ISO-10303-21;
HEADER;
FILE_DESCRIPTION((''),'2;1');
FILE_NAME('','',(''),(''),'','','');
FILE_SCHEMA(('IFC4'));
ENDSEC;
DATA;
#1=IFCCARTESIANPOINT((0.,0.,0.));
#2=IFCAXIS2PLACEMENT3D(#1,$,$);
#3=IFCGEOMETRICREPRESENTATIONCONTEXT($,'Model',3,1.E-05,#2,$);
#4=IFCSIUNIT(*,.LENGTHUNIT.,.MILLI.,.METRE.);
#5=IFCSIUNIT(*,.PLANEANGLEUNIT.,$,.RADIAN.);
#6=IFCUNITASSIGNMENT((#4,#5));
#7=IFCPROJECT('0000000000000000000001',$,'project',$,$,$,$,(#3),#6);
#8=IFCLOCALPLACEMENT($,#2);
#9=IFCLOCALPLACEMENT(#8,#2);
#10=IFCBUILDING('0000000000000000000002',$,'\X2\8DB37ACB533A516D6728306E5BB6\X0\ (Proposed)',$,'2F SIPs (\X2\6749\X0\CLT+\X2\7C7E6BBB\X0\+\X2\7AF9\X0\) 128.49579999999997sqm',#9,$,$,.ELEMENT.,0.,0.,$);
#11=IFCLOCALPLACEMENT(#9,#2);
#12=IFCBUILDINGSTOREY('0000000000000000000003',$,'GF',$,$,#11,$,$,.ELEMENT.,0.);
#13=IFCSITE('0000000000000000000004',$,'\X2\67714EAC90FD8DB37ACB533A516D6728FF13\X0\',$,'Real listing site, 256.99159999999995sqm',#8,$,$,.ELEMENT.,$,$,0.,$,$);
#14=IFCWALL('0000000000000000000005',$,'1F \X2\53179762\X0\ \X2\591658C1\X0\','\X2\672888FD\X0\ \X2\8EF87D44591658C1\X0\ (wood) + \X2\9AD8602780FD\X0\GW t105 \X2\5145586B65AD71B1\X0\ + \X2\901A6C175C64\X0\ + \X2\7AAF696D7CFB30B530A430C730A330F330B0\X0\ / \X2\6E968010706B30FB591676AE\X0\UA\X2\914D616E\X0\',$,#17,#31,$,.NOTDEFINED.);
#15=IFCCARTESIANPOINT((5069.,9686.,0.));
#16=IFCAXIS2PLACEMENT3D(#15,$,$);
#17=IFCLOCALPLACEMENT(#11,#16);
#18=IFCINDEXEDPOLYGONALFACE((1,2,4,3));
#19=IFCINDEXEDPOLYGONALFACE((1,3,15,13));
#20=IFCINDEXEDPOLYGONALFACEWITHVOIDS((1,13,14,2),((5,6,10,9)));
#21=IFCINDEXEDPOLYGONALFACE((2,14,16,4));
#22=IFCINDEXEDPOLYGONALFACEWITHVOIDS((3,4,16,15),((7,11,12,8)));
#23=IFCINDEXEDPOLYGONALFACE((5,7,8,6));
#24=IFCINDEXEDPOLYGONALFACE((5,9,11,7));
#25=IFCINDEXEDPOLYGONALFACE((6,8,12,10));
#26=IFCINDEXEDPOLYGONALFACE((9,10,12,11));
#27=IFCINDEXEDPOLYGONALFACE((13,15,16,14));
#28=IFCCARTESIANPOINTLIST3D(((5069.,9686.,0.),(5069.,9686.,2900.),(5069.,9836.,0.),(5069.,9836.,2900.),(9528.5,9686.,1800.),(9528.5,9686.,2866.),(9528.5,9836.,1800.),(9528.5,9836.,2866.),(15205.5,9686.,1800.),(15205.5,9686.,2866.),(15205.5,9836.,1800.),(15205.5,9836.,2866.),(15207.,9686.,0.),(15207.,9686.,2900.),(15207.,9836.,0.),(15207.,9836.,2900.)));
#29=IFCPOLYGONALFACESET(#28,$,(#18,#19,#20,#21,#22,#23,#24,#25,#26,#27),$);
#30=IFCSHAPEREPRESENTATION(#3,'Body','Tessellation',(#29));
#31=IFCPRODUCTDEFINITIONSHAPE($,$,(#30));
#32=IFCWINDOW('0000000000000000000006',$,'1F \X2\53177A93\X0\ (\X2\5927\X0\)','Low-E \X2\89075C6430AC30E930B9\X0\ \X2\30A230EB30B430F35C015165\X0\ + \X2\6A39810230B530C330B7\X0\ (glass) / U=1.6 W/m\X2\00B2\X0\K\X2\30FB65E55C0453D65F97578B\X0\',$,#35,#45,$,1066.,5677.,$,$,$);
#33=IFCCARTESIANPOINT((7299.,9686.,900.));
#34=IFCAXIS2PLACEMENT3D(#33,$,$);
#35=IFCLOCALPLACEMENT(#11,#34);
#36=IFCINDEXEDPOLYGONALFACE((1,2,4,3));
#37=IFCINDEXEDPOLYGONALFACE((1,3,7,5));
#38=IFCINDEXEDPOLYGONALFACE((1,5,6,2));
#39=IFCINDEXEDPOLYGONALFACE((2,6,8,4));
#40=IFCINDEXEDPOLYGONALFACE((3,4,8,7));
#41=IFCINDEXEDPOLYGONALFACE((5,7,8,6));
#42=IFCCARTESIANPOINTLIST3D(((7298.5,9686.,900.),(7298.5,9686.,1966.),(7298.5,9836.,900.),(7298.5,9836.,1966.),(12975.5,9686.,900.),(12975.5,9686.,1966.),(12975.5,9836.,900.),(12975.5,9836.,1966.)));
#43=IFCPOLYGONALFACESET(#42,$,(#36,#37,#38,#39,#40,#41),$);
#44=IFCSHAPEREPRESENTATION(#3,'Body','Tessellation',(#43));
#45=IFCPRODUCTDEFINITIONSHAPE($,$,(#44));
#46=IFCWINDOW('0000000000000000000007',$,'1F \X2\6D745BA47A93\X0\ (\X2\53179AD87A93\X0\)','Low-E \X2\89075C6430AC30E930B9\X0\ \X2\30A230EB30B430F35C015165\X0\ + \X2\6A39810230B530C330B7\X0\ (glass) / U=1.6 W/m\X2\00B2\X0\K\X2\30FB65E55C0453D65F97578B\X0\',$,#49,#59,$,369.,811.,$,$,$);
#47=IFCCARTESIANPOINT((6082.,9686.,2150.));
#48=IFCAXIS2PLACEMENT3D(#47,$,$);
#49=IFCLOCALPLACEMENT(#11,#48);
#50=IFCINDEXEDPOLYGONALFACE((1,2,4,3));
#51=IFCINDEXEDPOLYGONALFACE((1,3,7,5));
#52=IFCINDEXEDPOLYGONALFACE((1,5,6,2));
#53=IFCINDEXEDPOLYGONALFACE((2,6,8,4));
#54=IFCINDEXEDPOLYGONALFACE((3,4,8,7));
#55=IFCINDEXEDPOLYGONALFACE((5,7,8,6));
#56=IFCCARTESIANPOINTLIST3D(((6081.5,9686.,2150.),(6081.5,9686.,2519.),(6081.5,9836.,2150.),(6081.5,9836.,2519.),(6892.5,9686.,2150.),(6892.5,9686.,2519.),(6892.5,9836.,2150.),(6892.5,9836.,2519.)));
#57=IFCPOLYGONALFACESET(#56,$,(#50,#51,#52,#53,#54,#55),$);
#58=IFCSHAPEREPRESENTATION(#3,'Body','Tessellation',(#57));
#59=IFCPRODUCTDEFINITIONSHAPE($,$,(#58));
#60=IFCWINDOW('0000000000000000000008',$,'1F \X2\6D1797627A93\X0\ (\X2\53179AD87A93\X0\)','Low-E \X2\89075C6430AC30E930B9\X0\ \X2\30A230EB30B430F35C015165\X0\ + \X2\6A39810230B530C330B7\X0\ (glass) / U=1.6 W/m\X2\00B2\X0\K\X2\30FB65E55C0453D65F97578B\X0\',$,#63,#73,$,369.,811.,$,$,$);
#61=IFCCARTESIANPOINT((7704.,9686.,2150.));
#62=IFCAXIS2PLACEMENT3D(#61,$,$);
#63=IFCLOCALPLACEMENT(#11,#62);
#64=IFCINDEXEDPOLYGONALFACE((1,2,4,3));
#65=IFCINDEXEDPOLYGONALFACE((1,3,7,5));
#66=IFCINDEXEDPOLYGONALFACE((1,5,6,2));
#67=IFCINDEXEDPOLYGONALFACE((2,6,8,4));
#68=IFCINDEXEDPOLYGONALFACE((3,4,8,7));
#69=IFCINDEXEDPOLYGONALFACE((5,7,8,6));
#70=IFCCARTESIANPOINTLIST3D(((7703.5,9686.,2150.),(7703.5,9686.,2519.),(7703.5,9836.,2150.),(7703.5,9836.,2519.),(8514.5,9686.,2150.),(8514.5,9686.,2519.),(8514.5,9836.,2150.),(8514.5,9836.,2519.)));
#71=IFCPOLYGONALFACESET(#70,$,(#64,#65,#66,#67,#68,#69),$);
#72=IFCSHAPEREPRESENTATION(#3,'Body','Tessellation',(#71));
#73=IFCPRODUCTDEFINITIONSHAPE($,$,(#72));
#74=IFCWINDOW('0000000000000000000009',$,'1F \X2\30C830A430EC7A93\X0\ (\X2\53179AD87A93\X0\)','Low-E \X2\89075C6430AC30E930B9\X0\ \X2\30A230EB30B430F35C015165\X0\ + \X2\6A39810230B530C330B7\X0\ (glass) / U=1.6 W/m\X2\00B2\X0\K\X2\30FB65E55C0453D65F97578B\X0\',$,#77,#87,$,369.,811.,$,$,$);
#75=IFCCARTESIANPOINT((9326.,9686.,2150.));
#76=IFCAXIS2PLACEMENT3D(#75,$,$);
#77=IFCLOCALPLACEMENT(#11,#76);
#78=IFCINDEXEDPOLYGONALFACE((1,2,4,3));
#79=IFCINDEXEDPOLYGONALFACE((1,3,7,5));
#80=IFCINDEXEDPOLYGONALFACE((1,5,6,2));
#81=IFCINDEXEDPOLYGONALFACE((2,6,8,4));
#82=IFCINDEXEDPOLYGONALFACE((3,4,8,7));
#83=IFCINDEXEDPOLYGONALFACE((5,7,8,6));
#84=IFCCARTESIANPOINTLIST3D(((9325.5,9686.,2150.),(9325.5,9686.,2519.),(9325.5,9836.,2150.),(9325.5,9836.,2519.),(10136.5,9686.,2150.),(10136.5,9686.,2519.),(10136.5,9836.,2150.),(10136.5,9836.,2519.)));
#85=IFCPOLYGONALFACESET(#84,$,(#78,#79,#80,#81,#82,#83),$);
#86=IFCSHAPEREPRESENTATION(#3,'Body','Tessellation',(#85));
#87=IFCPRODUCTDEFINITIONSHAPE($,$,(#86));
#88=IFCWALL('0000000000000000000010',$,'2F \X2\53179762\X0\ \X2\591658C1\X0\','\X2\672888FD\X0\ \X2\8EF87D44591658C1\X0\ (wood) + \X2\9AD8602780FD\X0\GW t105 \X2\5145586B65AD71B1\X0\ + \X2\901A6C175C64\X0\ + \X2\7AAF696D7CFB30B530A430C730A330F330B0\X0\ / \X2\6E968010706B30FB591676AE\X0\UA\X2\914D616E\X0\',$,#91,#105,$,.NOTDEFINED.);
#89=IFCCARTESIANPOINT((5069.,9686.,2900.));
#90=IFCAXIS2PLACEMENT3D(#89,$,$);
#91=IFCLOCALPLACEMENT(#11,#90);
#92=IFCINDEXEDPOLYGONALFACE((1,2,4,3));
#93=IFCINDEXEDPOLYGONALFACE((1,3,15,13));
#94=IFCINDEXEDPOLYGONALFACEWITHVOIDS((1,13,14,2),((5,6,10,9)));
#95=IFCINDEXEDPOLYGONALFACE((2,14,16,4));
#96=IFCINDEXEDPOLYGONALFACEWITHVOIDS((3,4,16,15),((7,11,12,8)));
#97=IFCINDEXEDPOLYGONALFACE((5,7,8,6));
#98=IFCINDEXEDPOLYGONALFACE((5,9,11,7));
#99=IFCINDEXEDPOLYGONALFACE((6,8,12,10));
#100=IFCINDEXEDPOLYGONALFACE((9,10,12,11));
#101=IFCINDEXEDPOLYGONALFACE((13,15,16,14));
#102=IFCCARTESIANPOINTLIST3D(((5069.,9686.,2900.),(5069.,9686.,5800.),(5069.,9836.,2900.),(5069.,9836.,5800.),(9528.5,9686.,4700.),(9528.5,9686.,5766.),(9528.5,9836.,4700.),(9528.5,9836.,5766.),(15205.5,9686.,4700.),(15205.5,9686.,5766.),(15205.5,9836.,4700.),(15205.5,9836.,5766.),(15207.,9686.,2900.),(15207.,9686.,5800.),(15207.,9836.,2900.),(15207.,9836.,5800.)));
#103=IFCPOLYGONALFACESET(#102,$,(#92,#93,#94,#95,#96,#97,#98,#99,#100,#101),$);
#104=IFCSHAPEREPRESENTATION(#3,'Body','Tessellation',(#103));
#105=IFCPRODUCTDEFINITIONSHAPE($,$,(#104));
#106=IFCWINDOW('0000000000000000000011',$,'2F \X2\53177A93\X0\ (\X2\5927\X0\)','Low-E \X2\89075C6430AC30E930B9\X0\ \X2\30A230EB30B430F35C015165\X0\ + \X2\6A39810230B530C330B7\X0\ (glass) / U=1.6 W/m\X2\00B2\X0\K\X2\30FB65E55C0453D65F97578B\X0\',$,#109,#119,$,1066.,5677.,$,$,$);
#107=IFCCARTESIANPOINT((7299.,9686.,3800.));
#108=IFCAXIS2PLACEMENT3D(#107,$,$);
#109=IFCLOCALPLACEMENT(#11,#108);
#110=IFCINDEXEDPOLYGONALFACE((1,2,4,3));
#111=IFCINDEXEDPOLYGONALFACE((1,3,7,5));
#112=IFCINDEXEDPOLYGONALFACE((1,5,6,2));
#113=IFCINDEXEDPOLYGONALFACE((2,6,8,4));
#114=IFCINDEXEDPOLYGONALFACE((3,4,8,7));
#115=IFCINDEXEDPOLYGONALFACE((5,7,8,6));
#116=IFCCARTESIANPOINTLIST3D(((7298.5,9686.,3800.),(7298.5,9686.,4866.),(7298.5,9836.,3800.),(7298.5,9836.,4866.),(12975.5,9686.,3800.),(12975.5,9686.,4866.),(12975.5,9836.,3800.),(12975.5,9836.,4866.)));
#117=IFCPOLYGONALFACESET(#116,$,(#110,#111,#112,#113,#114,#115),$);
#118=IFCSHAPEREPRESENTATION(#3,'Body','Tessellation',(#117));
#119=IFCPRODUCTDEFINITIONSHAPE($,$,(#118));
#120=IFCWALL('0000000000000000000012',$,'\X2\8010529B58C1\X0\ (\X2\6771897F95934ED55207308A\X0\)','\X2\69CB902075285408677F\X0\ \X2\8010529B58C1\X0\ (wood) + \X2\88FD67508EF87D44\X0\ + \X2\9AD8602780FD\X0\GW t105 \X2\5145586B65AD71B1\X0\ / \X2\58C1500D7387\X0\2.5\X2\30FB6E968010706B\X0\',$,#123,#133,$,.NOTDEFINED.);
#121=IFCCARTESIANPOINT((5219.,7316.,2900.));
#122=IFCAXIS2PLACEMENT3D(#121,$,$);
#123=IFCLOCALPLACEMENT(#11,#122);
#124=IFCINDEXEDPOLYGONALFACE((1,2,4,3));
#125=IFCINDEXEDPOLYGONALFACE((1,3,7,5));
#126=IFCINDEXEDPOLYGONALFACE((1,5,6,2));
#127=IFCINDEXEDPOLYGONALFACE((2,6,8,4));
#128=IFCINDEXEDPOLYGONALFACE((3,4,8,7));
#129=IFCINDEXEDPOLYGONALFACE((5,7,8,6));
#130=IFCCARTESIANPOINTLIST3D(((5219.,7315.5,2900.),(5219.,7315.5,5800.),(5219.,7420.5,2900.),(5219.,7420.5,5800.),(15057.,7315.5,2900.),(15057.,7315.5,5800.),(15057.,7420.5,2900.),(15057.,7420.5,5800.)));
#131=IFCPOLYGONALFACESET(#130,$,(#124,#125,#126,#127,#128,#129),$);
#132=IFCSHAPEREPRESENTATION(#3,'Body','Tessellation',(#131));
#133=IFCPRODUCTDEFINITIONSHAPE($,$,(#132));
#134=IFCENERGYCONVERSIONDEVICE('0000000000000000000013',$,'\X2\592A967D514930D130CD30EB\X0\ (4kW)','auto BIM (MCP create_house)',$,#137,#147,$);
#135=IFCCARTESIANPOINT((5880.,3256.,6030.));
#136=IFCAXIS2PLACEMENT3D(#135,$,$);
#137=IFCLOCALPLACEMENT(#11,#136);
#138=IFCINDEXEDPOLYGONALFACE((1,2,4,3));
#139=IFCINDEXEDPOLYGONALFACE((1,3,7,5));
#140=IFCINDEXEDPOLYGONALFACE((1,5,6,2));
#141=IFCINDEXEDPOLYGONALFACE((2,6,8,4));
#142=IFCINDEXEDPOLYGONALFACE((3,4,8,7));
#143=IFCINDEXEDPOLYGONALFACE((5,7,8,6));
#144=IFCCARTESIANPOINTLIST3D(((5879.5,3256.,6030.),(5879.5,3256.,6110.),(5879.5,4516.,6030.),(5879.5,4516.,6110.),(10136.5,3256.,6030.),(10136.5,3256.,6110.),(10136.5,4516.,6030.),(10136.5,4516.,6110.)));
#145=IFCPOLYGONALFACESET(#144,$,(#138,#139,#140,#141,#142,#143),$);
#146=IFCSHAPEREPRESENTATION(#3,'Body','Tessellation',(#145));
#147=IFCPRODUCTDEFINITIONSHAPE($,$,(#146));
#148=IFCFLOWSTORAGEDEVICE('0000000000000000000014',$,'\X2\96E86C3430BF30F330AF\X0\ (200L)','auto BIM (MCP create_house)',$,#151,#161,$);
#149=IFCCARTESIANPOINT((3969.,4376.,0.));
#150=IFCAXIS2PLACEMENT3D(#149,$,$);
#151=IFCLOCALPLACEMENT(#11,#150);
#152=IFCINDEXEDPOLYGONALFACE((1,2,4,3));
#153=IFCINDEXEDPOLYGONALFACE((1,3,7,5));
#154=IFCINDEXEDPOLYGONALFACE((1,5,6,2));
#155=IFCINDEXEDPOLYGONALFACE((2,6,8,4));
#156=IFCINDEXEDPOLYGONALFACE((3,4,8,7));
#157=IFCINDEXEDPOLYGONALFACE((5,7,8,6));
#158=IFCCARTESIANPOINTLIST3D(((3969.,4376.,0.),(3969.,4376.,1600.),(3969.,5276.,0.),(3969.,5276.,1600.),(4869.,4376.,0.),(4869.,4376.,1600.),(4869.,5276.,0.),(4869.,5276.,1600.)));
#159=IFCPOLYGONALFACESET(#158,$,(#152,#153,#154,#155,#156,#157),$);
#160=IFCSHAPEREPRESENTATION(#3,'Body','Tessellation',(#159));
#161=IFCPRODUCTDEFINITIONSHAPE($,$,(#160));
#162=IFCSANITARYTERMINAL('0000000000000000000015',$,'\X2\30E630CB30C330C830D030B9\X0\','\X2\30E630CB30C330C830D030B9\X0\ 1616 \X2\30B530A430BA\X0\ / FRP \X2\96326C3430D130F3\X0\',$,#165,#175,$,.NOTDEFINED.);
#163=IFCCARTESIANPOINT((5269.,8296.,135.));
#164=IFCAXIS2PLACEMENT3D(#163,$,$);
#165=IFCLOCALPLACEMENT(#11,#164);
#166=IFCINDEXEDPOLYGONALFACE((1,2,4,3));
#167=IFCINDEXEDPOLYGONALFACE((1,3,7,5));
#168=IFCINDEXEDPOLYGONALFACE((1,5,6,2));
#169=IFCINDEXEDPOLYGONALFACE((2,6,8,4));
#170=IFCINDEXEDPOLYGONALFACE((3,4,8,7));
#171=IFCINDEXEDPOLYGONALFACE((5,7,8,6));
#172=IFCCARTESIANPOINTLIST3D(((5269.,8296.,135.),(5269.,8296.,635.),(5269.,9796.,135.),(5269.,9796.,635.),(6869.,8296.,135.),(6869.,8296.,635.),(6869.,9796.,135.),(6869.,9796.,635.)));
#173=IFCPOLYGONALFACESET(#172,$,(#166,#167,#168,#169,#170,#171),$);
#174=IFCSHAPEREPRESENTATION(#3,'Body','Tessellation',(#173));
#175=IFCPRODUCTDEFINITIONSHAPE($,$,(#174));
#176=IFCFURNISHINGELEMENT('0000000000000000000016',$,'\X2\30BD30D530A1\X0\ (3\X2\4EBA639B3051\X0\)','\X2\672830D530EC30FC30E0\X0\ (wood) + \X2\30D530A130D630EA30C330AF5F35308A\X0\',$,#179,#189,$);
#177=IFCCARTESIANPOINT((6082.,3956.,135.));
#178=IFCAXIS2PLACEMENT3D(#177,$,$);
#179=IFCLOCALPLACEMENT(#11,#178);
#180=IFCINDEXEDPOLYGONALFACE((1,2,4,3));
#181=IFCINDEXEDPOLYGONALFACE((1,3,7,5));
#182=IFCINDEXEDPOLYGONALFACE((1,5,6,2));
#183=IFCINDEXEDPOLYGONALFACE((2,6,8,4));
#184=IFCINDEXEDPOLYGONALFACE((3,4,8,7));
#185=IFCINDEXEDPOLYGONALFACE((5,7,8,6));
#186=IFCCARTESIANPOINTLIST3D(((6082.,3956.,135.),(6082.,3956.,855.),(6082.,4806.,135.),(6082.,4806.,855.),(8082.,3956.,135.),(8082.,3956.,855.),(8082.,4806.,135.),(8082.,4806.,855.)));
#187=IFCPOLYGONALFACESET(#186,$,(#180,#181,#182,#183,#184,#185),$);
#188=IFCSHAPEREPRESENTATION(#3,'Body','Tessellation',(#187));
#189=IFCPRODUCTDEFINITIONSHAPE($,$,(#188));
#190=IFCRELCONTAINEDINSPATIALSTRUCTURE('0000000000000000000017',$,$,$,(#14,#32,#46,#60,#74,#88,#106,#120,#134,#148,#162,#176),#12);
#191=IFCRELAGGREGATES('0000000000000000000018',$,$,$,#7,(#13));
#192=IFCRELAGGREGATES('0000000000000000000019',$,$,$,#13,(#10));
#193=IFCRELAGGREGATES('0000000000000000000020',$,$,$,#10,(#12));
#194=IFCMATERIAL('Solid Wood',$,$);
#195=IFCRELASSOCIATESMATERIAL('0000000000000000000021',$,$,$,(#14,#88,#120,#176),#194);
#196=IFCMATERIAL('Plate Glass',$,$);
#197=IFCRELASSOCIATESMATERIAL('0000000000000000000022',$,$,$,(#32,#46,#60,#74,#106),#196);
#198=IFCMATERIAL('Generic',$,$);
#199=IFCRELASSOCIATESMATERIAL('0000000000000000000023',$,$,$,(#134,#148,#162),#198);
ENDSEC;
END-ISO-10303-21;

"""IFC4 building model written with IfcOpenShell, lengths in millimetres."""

from ifc_helpers import new_model, si_unit, frame, frame_2d, origin, place, context, project, spatial, rectangle, extrude, material, element, fill, save


model = new_model("IFC4")

# Units and contexts
model_context = context("Model", 3, precision=1e-05, world=origin())
ifc_project = project(units=[si_unit("LENGTHUNIT", "METRE", prefix="MILLI"), si_unit("PLANEANGLEUNIT", "RADIAN")], contexts=[model_context])

# Site, building, storey
site_placement = place(None, origin())
site = spatial("IfcSite", under=ifc_project, at=site_placement, Name="東京都足立区六木３", ObjectType="Real listing site, 256.99159999999995sqm", CompositionType="ELEMENT", RefElevation=0.0)
building_placement = place(site_placement, origin())
building = spatial("IfcBuilding", under=site, at=building_placement, Name="足立区六木の家 (Proposed)", ObjectType="2F SIPs (杉CLT+籾殻+竹) 128.49579999999997sqm", CompositionType="ELEMENT", ElevationOfRefHeight=0.0, ElevationOfTerrain=0.0)
storey_placement = place(building_placement, origin())
storey = spatial("IfcBuildingStorey", under=building, at=storey_placement, Name="GF", CompositionType="ELEMENT", Elevation=0.0)

# Wall, openings, windows
ifc_material_1 = material(Name="Solid Wood")
wall_1_placement = place(storey_placement, frame((5069.0, 9686.0, 0.0)))
wall_1 = element("IfcWall", 1, at=wall_1_placement, inside=storey, material=ifc_material_1, Name="1F 北面 外壁", Description="木製 軸組外壁 (wood) + 高性能GW t105 充填断熱 + 通気層 + 窯業系サイディング / 準耐火・外皮UA配慮", PredefinedType="NOTDEFINED", context=model_context, shape_type="SweptSolid", body=[
    extrude(rectangle(XDim=10138.0, YDim=150.0, at=frame_2d((5069.0, 75.0))), frame((5069.0, 9686.0, 0.0)), (0.0, 0.0, 1.0), 2900.0),
])
opening_1_placement = place(storey_placement, frame((7299.0, 9686.0, 900.0)))
opening_1 = element("IfcOpeningElement", 2, at=opening_1_placement, cuts=wall_1, PredefinedType="NOTDEFINED", context=model_context, shape_type="SweptSolid", body=[
    extrude(rectangle(XDim=5677.0, YDim=150.0, at=frame_2d((2838.0, 75.0))), frame((7299.0, 9686.0, 900.0)), (0.0, 0.0, 1.0), 1066.0),
])
opening_2_placement = place(storey_placement, frame((6082.0, 9686.0, 2150.0)))
opening_2 = element("IfcOpeningElement", 3, at=opening_2_placement, cuts=wall_1, PredefinedType="NOTDEFINED", context=model_context, shape_type="SweptSolid", body=[
    extrude(rectangle(XDim=811.0, YDim=150.0, at=frame_2d((405.0, 75.0))), frame((6082.0, 9686.0, 2150.0)), (0.0, 0.0, 1.0), 369.0),
])
opening_3_placement = place(storey_placement, frame((7704.0, 9686.0, 2150.0)))
opening_3 = element("IfcOpeningElement", 4, at=opening_3_placement, cuts=wall_1, PredefinedType="NOTDEFINED", context=model_context, shape_type="SweptSolid", body=[
    extrude(rectangle(XDim=811.0, YDim=150.0, at=frame_2d((405.0, 75.0))), frame((7704.0, 9686.0, 2150.0)), (0.0, 0.0, 1.0), 369.0),
])
opening_4_placement = place(storey_placement, frame((9326.0, 9686.0, 2150.0)))
opening_4 = element("IfcOpeningElement", 5, at=opening_4_placement, cuts=wall_1, PredefinedType="NOTDEFINED", context=model_context, shape_type="SweptSolid", body=[
    extrude(rectangle(XDim=811.0, YDim=150.0, at=frame_2d((405.0, 75.0))), frame((9326.0, 9686.0, 2150.0)), (0.0, 0.0, 1.0), 369.0),
])
ifc_material_2 = material(Name="Plate Glass")
window_1_placement = place(storey_placement, frame((7299.0, 9686.0, 900.0)))
window_1 = element("IfcWindow", 6, at=window_1_placement, inside=storey, material=ifc_material_2, Name="1F 北窓 (大)", Description="Low-E 複層ガラス アルゴン封入 + 樹脂サッシ (glass) / U=1.6 W/m²K・日射取得型", OverallHeight=1066.0, OverallWidth=5677.0, context=model_context, shape_type="SweptSolid", body=[
    extrude(rectangle(XDim=5677.0, YDim=150.0, at=frame_2d((2838.0, 75.0))), frame((7299.0, 9686.0, 900.0)), (0.0, 0.0, 1.0), 1066.0),
])
fill(opening_1, window_1)
window_2_placement = place(storey_placement, frame((6082.0, 9686.0, 2150.0)))
window_2 = element("IfcWindow", 7, at=window_2_placement, inside=storey, material=ifc_material_2, Name="1F 浴室窓 (北高窓)", Description="Low-E 複層ガラス アルゴン封入 + 樹脂サッシ (glass) / U=1.6 W/m²K・日射取得型", OverallHeight=369.0, OverallWidth=811.0, context=model_context, shape_type="SweptSolid", body=[
    extrude(rectangle(XDim=811.0, YDim=150.0, at=frame_2d((405.0, 75.0))), frame((6082.0, 9686.0, 2150.0)), (0.0, 0.0, 1.0), 369.0),
])
fill(opening_2, window_2)
window_3_placement = place(storey_placement, frame((7704.0, 9686.0, 2150.0)))
window_3 = element("IfcWindow", 8, at=window_3_placement, inside=storey, material=ifc_material_2, Name="1F 洗面窓 (北高窓)", Description="Low-E 複層ガラス アルゴン封入 + 樹脂サッシ (glass) / U=1.6 W/m²K・日射取得型", OverallHeight=369.0, OverallWidth=811.0, context=model_context, shape_type="SweptSolid", body=[
    extrude(rectangle(XDim=811.0, YDim=150.0, at=frame_2d((405.0, 75.0))), frame((7704.0, 9686.0, 2150.0)), (0.0, 0.0, 1.0), 369.0),
])
fill(opening_3, window_3)
window_4_placement = place(storey_placement, frame((9326.0, 9686.0, 2150.0)))
window_4 = element("IfcWindow", 9, at=window_4_placement, inside=storey, material=ifc_material_2, Name="1F トイレ窓 (北高窓)", Description="Low-E 複層ガラス アルゴン封入 + 樹脂サッシ (glass) / U=1.6 W/m²K・日射取得型", OverallHeight=369.0, OverallWidth=811.0, context=model_context, shape_type="SweptSolid", body=[
    extrude(rectangle(XDim=811.0, YDim=150.0, at=frame_2d((405.0, 75.0))), frame((9326.0, 9686.0, 2150.0)), (0.0, 0.0, 1.0), 369.0),
])
fill(opening_4, window_4)

# Wall, opening, window
wall_2_placement = place(storey_placement, frame((5069.0, 9686.0, 2900.0)))
wall_2 = element("IfcWall", 10, at=wall_2_placement, inside=storey, material=ifc_material_1, Name="2F 北面 外壁", Description="木製 軸組外壁 (wood) + 高性能GW t105 充填断熱 + 通気層 + 窯業系サイディング / 準耐火・外皮UA配慮", PredefinedType="NOTDEFINED", context=model_context, shape_type="SweptSolid", body=[
    extrude(rectangle(XDim=10138.0, YDim=150.0, at=frame_2d((5069.0, 75.0))), frame((5069.0, 9686.0, 2900.0)), (0.0, 0.0, 1.0), 2900.0),
])
opening_5_placement = place(storey_placement, frame((7299.0, 9686.0, 3800.0)))
opening_5 = element("IfcOpeningElement", 11, at=opening_5_placement, cuts=wall_2, PredefinedType="NOTDEFINED", context=model_context, shape_type="SweptSolid", body=[
    extrude(rectangle(XDim=5677.0, YDim=150.0, at=frame_2d((2838.0, 75.0))), frame((7299.0, 9686.0, 3800.0)), (0.0, 0.0, 1.0), 1066.0),
])
window_5_placement = place(storey_placement, frame((7299.0, 9686.0, 3800.0)))
window_5 = element("IfcWindow", 12, at=window_5_placement, inside=storey, material=ifc_material_2, Name="2F 北窓 (大)", Description="Low-E 複層ガラス アルゴン封入 + 樹脂サッシ (glass) / U=1.6 W/m²K・日射取得型", OverallHeight=1066.0, OverallWidth=5677.0, context=model_context, shape_type="SweptSolid", body=[
    extrude(rectangle(XDim=5677.0, YDim=150.0, at=frame_2d((2838.0, 75.0))), frame((7299.0, 9686.0, 3800.0)), (0.0, 0.0, 1.0), 1066.0),
])
fill(opening_5, window_5)

# Wall
wall_3_placement = place(storey_placement, frame((5219.0, 7316.0, 2900.0)))
element("IfcWall", 13, at=wall_3_placement, inside=storey, material=ifc_material_1, Name="耐力壁 (東西間仕切り)", Description="構造用合板 耐力壁 (wood) + 製材軸組 + 高性能GW t105 充填断熱 / 壁倍率2.5・準耐火", PredefinedType="NOTDEFINED", context=model_context, shape_type="SweptSolid", body=[
    extrude(rectangle(XDim=9838.0, YDim=105.0, at=frame_2d((4919.0, 52.0))), frame((5219.0, 7316.0, 2900.0)), (0.0, 0.0, 1.0), 2900.0),
])

# Energy conversion device
ifc_material_3 = material(Name="Generic")
energy_conversion_device_placement = place(storey_placement, frame((5880.0, 3256.0, 6030.0)))
element("IfcEnergyConversionDevice", 14, at=energy_conversion_device_placement, inside=storey, material=ifc_material_3, Name="太陽光パネル (4kW)", Description="auto BIM (MCP create_house)", context=model_context, shape_type="SweptSolid", body=[
    extrude(rectangle(XDim=4257.0, YDim=1260.0, at=frame_2d((2128.0, 630.0))), frame((5880.0, 3256.0, 6030.0)), (0.0, 0.0, 1.0), 80.0),
])

# Flow storage device
flow_storage_device_placement = place(storey_placement, frame((3969.0, 4376.0, 0.0)))
element("IfcFlowStorageDevice", 15, at=flow_storage_device_placement, inside=storey, material=ifc_material_3, Name="雨水タンク (200L)", Description="auto BIM (MCP create_house)", context=model_context, shape_type="SweptSolid", body=[
    extrude(rectangle(XDim=900.0, YDim=900.0, at=frame_2d((450.0, 450.0))), frame((3969.0, 4376.0, 0.0)), (0.0, 0.0, 1.0), 1600.0),
])

# Sanitary terminal
sanitary_terminal_placement = place(storey_placement, frame((5269.0, 8296.0, 135.0)))
element("IfcSanitaryTerminal", 16, at=sanitary_terminal_placement, inside=storey, material=ifc_material_3, Name="ユニットバス", Description="ユニットバス 1616 サイズ / FRP 防水パン", PredefinedType="NOTDEFINED", context=model_context, shape_type="SweptSolid", body=[
    extrude(rectangle(XDim=1600.0, YDim=1500.0, at=frame_2d((800.0, 750.0))), frame((5269.0, 8296.0, 135.0)), (0.0, 0.0, 1.0), 500.0),
])

# Furnishing element
furnishing_1_placement = place(storey_placement, frame((6082.0, 3956.0, 135.0)))
element("IfcFurnishingElement", 17, at=furnishing_1_placement, inside=storey, material=ifc_material_1, Name="ソファ (3人掛け)", Description="木フレーム (wood) + ファブリック張り", context=model_context, shape_type="SweptSolid", body=[
    extrude(rectangle(XDim=2000.0, YDim=850.0, at=frame_2d((1000.0, 425.0))), frame((6082.0, 3956.0, 135.0)), (0.0, 0.0, 1.0), 720.0),
])

save(model, "model.ifc")
